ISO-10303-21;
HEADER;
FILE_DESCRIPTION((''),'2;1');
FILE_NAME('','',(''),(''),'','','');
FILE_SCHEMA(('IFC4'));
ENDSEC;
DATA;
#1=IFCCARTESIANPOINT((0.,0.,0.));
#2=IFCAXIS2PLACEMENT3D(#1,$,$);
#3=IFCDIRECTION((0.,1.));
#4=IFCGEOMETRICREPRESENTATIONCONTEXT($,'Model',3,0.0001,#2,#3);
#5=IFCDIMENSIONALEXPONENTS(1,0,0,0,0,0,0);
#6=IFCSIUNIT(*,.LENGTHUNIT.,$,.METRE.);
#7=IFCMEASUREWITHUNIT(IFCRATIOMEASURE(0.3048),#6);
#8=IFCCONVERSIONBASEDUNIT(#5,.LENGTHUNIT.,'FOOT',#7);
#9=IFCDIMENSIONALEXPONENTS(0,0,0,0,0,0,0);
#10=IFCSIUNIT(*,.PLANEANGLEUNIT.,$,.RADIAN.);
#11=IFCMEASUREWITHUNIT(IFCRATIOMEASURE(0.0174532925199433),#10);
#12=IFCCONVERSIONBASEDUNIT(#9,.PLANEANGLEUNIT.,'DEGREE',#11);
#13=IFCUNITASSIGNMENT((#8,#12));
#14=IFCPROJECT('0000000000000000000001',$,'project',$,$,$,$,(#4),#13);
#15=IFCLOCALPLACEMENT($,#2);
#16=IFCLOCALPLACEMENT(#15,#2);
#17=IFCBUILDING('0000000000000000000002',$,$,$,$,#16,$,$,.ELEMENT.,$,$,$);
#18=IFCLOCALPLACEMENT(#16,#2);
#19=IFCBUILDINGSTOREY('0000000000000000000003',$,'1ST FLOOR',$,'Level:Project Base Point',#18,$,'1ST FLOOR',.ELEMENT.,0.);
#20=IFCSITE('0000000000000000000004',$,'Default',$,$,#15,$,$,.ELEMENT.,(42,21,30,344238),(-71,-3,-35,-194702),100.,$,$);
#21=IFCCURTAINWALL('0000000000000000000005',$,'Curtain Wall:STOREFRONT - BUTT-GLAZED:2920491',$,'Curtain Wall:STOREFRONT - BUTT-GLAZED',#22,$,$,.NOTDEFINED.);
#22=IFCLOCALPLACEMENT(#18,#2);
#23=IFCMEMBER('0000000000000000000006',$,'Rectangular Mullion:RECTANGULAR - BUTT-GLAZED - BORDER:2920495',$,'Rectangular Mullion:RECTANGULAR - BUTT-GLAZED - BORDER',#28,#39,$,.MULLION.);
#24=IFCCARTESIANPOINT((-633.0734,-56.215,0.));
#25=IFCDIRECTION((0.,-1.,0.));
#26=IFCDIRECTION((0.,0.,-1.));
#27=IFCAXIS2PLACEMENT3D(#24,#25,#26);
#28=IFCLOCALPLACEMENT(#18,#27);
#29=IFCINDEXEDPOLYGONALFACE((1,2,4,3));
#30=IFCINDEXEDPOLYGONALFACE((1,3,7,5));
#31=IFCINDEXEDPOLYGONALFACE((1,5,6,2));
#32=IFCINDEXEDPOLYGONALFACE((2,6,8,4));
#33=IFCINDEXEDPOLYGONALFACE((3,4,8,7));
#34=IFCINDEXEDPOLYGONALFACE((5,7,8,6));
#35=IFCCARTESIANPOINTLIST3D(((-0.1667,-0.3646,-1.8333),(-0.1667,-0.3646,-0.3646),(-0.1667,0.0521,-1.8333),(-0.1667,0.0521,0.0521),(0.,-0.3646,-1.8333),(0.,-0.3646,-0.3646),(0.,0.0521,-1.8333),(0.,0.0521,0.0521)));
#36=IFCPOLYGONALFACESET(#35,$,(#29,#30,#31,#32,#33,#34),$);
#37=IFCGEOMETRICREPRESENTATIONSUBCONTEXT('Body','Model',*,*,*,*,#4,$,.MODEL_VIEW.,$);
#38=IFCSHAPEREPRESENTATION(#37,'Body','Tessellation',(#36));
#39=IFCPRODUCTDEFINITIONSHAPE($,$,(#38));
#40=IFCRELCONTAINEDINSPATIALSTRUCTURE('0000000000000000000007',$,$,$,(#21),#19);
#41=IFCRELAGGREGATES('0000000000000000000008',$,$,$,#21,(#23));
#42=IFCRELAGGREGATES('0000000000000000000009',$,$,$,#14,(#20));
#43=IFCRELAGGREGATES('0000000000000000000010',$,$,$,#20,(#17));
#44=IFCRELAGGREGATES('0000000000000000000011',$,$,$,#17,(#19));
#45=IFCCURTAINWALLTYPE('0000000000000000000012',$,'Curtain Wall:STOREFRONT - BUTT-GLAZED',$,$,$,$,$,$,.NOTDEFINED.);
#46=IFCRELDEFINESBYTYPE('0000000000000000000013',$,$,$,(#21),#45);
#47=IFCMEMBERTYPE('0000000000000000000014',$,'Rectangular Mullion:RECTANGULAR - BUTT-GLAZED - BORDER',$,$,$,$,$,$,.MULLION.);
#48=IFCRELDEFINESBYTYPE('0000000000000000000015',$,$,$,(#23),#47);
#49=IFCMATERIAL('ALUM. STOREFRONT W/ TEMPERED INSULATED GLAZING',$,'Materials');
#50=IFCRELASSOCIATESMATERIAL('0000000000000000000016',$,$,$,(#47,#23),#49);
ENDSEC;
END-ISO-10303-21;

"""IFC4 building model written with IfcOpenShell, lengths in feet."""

from ifc_helpers import new_model, entity, si_unit, converted_unit, direction, frame, frame_2d, origin, place, context, subcontext, project, spatial, rectangle, extrude, clip, halfspace, source, transform, mapped, material, material_profile, profile_set, profile_usage, type_object, type_shapes, element, aggregate, save


model = new_model("IFC4")

# Units and contexts
model_context = context("Model", 3, precision=0.0001, world=origin(), true_north=direction((0.0, 1.0)))
body_context = subcontext(model_context, "Body", "Model", "MODEL_VIEW")
ifc_project = project(units=[converted_unit("LENGTHUNIT", "FOOT", entity("IfcRatioMeasure", 0.3048), si_unit("LENGTHUNIT", "METRE"), dimensions=[1, 0, 0, 0, 0, 0, 0]), converted_unit("PLANEANGLEUNIT", "DEGREE", entity("IfcRatioMeasure", 0.0174532925199433), si_unit("PLANEANGLEUNIT", "RADIAN"), dimensions=[0, 0, 0, 0, 0, 0, 0])], contexts=[model_context])

# Site, building, storey
site_placement = place(None, origin())
site = spatial("IfcSite", under=ifc_project, at=site_placement, Name="Default", CompositionType="ELEMENT", RefLatitude=(42, 21, 30, 344238), RefLongitude=(-71, -3, -35, -194702), RefElevation=100.0)
building_placement = place(site_placement, origin())
building = spatial("IfcBuilding", under=site, at=building_placement, CompositionType="ELEMENT")
storey_placement = place(building_placement, origin())
storey = spatial("IfcBuildingStorey", under=building, at=storey_placement, Name="1ST FLOOR", ObjectType="Level:Project Base Point", LongName="1ST FLOOR", CompositionType="ELEMENT", Elevation=0.0)

# Shared definitions
ifc_material_1 = material(Name="ALUM. STOREFRONT W/ TEMPERED INSULATED GLAZING", Category="Materials")

# Curtain wall, member
curtain_wall_type_1 = type_object("IfcCurtainWallType", Name="Curtain Wall:STOREFRONT - BUTT-GLAZED", PredefinedType="NOTDEFINED")
ifc_material_profile_1 = material_profile(ifc_material_1, rectangle(XDim=0.4167, YDim=0.1667, at=frame_2d((0.0, 0.0), x_axis=(1.0, 0.0))), Name="RECTANGULAR - BUTT-GLAZED - BORDER")
ifc_profile_set_1 = profile_set([ifc_material_profile_1], Name="RECTANGULAR - BUTT-GLAZED - BORDER")
curtain_wall_1_placement = place(storey_placement, origin())
curtain_wall_1 = element("IfcCurtainWall", 1, at=curtain_wall_1_placement, inside=storey, type_object=curtain_wall_type_1, Name="Curtain Wall:STOREFRONT - BUTT-GLAZED:2920491", ObjectType="Curtain Wall:STOREFRONT - BUTT-GLAZED", PredefinedType="NOTDEFINED")
ifc_profile_usage_1 = profile_usage(ifc_profile_set_1)
member_type_1 = type_object("IfcMemberType", Name="Rectangular Mullion:RECTANGULAR - BUTT-GLAZED - BORDER", PredefinedType="MULLION", material=ifc_profile_set_1)
shared_shape_1 = source(origin(), body_context, "Body", "Clipping", [
    clip(extrude(rectangle(XDim=0.4167, YDim=0.1667, at=frame_2d((0.0, 0.0), x_axis=(1.0, 0.0))), frame((-0.0833, -0.1562, -1.8333), z_axis=(0.0, 0.0, 1.0), x_axis=(0.0, -1.0, 0.0)), (0.0, 0.0, 1.0), 1.8854), halfspace(frame((1.0, 0.0, 0.0), z_axis=(0.0, -0.707107, 0.707107), x_axis=(0.0, -0.707107, -0.707107)), False)),
])
type_shapes(member_type_1, [shared_shape_1])
member_1_placement = place(storey_placement, frame((-633.0734, -56.215, 0.0), z_axis=(0.0, -1.0, 0.0), x_axis=(0.0, 0.0, -1.0)))
member_1 = element("IfcMember", 2, at=member_1_placement, type_object=member_type_1, material=ifc_profile_usage_1, Name="Rectangular Mullion:RECTANGULAR - BUTT-GLAZED - BORDER:2920495", ObjectType="Rectangular Mullion:RECTANGULAR - BUTT-GLAZED - BORDER", PredefinedType="MULLION", context=body_context, shape_type="MappedRepresentation", body=[
    mapped(shared_shape_1, transform((0.0, 0.0, 0.0), scale=1.0)),
])

aggregate(curtain_wall_1, [member_1])

save(model, "model.ifc")
